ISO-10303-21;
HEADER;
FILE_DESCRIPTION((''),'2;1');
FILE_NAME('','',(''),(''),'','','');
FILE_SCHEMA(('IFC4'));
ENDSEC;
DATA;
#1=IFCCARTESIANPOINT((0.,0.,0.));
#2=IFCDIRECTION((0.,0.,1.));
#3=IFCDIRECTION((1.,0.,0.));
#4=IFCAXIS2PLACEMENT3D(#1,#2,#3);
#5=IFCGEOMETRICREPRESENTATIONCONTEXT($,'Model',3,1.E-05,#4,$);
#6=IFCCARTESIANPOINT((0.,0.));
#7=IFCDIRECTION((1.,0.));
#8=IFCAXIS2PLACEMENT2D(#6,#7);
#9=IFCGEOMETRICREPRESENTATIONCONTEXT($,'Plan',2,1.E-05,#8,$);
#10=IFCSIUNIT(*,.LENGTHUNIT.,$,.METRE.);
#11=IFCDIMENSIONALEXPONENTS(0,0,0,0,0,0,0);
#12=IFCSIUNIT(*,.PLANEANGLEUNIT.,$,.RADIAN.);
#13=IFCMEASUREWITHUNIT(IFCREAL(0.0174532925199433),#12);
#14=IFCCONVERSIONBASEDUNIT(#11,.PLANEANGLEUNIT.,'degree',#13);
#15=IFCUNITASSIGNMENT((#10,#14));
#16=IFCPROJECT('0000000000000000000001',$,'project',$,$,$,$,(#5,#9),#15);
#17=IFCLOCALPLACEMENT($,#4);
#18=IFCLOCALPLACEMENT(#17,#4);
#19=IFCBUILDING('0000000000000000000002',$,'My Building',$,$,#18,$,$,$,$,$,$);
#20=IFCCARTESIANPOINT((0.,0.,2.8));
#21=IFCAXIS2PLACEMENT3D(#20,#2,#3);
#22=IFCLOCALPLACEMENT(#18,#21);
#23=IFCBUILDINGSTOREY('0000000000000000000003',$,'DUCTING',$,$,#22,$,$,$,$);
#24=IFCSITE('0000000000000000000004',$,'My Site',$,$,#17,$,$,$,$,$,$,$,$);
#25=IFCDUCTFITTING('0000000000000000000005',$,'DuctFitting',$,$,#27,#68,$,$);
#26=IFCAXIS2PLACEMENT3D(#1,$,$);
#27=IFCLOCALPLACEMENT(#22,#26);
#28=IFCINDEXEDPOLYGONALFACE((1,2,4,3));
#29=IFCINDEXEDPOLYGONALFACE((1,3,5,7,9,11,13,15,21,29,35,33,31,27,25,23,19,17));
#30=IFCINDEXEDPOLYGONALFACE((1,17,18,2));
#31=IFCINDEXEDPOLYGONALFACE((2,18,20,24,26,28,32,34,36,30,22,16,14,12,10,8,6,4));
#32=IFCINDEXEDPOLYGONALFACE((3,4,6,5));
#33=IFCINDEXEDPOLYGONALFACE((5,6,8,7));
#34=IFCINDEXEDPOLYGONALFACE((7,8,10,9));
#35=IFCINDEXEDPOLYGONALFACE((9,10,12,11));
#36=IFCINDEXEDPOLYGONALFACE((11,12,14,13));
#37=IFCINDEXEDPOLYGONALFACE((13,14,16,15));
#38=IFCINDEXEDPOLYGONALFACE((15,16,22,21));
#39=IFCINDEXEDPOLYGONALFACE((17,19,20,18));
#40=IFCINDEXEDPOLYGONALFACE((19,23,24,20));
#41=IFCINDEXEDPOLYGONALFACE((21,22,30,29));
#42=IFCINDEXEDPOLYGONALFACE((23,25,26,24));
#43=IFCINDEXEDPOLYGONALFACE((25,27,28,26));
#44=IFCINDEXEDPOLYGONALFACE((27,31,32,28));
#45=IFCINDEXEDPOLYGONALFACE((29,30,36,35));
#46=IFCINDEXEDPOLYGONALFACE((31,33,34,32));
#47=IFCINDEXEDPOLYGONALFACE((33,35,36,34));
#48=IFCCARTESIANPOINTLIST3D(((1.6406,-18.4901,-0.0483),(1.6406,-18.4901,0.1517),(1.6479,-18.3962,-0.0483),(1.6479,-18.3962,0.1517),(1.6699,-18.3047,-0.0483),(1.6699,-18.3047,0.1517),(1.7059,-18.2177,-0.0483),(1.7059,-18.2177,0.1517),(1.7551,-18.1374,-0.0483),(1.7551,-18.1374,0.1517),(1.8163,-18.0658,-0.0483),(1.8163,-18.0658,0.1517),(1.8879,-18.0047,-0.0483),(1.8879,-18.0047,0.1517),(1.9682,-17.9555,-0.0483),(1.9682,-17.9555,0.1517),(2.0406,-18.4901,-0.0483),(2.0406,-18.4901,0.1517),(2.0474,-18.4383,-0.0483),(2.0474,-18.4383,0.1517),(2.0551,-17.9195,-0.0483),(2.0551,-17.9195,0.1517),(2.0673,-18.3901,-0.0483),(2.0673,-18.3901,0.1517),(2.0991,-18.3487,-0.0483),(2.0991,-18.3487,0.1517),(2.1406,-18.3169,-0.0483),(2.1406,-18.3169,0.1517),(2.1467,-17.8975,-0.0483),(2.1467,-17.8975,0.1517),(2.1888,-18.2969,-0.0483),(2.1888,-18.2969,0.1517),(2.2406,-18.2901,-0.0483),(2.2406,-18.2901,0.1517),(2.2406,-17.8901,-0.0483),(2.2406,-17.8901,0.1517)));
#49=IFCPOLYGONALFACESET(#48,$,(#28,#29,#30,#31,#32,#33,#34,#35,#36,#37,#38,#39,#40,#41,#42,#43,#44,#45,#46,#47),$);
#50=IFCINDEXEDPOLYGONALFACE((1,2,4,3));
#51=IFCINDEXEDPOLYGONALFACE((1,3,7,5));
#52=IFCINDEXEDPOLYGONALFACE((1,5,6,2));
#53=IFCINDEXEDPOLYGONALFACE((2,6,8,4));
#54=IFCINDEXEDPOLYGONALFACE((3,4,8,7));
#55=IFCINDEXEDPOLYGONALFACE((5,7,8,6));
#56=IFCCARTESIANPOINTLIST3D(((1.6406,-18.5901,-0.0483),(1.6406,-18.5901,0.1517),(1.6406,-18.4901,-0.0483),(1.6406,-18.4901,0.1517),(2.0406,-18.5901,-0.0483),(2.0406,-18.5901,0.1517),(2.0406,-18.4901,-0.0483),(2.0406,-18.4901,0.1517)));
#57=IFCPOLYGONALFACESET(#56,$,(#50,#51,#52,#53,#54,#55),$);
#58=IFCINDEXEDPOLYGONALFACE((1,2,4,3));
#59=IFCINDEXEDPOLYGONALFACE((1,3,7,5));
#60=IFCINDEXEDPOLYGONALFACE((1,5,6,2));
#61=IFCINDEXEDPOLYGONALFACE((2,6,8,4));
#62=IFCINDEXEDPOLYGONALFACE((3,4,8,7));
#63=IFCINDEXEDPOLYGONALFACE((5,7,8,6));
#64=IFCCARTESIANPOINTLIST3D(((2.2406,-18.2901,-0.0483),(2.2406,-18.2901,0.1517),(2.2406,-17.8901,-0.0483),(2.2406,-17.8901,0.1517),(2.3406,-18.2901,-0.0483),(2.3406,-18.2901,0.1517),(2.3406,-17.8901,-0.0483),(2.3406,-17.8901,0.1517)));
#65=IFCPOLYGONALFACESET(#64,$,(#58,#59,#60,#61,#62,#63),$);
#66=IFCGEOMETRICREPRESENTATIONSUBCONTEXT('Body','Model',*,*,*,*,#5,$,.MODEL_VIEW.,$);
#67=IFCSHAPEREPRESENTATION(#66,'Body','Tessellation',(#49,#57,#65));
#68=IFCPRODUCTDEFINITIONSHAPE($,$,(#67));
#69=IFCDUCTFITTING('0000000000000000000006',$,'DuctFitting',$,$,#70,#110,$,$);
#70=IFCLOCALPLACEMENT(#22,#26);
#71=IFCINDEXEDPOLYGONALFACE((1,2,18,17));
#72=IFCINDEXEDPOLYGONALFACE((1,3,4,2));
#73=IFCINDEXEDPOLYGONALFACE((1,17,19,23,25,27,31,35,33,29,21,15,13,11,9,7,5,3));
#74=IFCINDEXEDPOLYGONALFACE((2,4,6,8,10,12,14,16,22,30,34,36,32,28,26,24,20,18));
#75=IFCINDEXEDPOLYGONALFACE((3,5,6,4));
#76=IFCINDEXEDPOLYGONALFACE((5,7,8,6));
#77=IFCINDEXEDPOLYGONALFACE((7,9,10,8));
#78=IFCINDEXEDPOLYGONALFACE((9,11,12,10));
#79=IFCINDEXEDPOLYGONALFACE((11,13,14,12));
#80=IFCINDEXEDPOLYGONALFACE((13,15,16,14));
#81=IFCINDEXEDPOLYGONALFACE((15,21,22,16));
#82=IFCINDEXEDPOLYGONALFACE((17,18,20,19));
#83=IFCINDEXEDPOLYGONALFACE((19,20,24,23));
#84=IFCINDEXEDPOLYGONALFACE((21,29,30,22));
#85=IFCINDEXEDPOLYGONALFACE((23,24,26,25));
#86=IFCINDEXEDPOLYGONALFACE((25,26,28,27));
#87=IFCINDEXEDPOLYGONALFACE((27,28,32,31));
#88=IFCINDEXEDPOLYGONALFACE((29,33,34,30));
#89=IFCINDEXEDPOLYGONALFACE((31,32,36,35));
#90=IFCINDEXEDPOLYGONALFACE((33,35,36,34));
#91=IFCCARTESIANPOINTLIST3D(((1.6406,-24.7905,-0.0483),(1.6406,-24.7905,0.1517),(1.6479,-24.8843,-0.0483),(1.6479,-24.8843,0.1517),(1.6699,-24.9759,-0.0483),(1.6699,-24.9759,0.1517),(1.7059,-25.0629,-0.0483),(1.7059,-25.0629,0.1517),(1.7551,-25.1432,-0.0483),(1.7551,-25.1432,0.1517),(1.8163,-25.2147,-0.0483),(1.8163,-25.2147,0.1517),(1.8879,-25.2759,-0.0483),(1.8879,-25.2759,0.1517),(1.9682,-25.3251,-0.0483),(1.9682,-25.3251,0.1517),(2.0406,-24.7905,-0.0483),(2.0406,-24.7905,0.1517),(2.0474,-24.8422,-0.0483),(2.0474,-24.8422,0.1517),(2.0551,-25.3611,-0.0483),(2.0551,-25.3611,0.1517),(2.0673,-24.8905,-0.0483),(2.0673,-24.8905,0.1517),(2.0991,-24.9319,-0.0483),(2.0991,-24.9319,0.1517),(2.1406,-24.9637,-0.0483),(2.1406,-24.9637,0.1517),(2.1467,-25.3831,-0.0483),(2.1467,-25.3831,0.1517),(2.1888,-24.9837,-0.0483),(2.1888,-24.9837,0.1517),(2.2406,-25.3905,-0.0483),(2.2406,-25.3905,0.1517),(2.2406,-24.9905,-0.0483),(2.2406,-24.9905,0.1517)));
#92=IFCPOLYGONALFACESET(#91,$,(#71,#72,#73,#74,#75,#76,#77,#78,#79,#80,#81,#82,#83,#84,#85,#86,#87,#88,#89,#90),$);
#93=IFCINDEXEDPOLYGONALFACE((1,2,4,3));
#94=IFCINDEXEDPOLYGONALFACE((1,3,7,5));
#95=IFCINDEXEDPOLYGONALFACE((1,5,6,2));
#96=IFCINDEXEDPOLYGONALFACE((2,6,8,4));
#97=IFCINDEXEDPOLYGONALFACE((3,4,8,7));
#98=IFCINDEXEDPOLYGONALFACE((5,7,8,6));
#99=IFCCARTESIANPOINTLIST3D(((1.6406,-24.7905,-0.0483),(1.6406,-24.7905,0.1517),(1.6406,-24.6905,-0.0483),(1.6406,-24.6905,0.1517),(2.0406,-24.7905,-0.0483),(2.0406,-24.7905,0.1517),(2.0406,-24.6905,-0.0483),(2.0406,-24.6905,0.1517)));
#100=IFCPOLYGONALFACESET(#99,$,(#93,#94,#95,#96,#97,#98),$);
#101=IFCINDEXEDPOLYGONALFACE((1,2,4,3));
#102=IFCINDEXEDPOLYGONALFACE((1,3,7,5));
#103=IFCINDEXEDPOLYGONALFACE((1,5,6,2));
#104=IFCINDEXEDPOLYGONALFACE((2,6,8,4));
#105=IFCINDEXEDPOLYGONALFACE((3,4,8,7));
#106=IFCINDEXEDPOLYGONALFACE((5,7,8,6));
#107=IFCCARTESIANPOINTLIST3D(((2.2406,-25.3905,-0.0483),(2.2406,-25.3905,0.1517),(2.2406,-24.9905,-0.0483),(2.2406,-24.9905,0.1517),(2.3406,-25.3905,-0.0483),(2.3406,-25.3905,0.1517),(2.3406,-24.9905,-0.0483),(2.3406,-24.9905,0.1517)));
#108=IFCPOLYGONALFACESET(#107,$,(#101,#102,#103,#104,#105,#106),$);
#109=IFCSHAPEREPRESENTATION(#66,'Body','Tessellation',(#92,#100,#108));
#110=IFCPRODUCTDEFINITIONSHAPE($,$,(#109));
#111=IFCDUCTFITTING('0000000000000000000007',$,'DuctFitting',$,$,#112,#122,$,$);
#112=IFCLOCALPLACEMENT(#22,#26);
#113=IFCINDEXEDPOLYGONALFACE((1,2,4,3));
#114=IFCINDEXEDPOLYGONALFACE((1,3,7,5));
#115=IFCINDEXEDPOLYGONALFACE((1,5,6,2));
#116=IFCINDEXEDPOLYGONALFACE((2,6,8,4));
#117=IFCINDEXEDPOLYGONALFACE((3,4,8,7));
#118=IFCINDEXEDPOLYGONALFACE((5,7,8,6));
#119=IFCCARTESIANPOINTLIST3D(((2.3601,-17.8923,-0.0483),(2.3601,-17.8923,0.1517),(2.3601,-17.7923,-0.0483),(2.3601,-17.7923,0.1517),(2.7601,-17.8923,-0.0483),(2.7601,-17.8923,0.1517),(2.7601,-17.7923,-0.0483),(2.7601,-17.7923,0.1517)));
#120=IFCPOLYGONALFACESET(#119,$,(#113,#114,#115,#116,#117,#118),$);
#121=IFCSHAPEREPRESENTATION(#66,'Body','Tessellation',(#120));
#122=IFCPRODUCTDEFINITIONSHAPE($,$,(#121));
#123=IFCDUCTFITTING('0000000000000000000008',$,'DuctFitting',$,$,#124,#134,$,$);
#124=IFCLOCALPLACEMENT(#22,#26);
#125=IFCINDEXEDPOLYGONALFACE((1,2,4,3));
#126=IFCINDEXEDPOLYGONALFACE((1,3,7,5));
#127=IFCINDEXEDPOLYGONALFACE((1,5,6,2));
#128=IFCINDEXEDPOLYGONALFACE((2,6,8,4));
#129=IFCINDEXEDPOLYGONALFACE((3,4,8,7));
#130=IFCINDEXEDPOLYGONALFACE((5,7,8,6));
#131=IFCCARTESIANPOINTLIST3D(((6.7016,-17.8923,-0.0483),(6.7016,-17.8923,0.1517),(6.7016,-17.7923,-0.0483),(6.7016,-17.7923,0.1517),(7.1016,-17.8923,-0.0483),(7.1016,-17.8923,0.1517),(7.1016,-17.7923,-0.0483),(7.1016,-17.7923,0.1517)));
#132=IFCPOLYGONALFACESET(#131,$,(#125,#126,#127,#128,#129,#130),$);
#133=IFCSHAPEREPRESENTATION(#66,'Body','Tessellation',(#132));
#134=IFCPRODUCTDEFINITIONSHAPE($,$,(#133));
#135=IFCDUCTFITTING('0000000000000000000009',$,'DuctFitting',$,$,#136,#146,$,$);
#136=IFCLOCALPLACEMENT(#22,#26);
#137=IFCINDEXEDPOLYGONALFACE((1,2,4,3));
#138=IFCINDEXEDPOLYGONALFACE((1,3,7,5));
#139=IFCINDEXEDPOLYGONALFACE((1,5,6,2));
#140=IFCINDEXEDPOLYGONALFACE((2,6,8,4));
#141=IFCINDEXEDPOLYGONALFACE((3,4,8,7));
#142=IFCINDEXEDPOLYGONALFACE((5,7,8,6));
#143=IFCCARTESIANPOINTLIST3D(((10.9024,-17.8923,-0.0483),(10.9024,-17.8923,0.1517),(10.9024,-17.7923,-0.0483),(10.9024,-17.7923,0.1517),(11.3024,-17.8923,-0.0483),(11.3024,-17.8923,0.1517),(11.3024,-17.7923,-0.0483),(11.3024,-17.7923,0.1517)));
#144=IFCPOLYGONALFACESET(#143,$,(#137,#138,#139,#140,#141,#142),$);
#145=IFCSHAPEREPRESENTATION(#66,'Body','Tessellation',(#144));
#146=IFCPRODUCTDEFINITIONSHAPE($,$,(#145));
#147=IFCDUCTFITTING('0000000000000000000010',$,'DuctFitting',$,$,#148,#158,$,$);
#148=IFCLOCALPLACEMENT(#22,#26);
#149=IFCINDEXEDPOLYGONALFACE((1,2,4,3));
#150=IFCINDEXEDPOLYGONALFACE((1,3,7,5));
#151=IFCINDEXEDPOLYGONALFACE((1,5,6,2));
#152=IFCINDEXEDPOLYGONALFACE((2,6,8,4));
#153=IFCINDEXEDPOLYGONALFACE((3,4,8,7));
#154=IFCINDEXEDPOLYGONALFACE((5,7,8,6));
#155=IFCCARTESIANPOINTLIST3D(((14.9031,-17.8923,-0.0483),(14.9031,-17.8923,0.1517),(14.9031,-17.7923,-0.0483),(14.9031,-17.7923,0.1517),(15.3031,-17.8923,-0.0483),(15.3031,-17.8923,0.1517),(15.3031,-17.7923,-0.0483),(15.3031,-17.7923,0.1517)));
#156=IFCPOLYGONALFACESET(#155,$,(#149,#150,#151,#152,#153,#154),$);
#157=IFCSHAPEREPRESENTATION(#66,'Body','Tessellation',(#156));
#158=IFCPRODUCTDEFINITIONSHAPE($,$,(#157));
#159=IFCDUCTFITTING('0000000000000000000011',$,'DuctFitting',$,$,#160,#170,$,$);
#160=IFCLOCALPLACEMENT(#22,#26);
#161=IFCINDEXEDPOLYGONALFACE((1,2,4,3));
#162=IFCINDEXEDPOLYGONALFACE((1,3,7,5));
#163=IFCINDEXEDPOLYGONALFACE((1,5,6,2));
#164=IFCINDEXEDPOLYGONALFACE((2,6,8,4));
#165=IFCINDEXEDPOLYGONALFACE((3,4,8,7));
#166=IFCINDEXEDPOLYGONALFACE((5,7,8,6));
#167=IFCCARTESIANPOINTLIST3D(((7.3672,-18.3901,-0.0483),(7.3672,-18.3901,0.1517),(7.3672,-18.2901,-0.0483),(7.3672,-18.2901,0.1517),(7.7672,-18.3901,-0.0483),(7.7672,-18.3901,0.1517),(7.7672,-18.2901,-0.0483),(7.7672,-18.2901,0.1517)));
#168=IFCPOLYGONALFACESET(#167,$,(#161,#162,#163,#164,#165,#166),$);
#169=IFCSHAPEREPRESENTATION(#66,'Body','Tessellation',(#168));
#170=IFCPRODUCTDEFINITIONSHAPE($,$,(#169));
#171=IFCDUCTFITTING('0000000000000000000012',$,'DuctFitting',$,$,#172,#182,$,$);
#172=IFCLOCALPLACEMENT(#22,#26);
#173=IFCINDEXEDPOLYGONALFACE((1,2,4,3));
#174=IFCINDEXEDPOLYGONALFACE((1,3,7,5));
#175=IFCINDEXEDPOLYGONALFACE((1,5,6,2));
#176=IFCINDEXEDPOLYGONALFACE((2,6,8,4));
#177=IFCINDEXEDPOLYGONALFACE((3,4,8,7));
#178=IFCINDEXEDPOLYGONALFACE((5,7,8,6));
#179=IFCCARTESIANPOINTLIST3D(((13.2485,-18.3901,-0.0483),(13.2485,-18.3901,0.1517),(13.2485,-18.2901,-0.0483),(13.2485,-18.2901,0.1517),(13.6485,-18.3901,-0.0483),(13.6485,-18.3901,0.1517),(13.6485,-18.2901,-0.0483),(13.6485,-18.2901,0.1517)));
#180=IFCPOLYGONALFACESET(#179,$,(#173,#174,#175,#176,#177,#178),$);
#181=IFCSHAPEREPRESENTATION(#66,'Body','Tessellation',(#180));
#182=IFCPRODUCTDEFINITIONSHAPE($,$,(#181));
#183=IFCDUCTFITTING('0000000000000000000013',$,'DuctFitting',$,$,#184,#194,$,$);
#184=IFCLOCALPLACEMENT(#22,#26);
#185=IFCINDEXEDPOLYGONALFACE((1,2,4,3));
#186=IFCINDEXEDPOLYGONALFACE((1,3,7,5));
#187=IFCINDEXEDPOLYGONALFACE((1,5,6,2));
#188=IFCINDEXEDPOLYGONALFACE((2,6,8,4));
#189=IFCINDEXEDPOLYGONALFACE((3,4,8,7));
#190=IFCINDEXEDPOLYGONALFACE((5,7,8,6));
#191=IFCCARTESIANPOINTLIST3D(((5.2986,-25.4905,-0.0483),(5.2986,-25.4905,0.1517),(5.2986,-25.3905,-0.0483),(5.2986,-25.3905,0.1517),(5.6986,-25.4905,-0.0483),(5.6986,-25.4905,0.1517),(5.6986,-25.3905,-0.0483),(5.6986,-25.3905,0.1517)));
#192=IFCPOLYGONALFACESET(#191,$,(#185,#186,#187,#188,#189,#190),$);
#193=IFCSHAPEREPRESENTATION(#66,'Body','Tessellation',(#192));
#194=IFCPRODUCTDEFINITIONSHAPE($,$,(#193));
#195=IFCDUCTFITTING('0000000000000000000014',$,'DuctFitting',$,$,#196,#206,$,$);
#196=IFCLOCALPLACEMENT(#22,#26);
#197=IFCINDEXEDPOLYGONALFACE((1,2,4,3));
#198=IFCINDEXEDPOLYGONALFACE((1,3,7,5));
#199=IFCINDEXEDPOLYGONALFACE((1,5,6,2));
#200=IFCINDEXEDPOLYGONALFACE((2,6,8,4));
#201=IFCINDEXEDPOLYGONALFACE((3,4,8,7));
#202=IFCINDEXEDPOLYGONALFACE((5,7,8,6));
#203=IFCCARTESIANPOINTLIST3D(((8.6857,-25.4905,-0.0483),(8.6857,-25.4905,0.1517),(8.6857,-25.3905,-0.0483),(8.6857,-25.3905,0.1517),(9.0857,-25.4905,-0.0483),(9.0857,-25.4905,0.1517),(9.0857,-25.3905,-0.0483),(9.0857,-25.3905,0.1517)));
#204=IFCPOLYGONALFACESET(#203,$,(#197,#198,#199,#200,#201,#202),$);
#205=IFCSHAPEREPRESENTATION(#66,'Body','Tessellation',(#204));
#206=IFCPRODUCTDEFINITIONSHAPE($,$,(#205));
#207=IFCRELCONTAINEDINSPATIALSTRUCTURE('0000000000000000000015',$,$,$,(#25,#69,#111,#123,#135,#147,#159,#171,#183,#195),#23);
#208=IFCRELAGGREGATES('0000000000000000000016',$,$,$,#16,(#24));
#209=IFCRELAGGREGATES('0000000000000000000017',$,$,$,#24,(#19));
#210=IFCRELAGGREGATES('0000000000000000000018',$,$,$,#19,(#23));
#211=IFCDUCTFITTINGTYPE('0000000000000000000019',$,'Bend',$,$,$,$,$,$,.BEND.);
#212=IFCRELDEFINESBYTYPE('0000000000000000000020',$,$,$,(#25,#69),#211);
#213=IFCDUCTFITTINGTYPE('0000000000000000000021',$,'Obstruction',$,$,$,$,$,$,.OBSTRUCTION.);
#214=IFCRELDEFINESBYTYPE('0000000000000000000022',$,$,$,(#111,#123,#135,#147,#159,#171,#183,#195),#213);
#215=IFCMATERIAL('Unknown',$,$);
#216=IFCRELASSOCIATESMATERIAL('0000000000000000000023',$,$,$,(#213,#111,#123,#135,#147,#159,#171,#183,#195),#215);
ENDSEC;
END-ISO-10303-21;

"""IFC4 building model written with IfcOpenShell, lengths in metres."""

from ifc_helpers import new_model, entity, si_unit, converted_unit, frame, origin_with_axes, origin_2d_with_axis, place, context, subcontext, project, spatial, line, arc, indexed_curve, rectangle, outline, extrude, source, transform, mapped, material, material_profile, profile_set, profile_usage, type_object, type_shapes, element, save


model = new_model("IFC4")

# Units and contexts
model_context = context("Model", 3, precision=1e-05, world=origin_with_axes())
plan_context = context("Plan", 2, precision=1e-05, world=origin_2d_with_axis())
body_context = subcontext(model_context, "Body", "Model", "MODEL_VIEW")
ifc_project = project(units=[si_unit("LENGTHUNIT", "METRE"), converted_unit("PLANEANGLEUNIT", "degree", entity("IfcReal", 0.0174532925199433), si_unit("PLANEANGLEUNIT", "RADIAN"), dimensions=[0, 0, 0, 0, 0, 0, 0])], contexts=[model_context, plan_context])

# Site, building, storey
site_placement = place(None, origin_with_axes())
site = spatial("IfcSite", under=ifc_project, at=site_placement, Name="My Site")
building_placement = place(site_placement, origin_with_axes())
building = spatial("IfcBuilding", under=site, at=building_placement, Name="My Building")
storey_placement = place(building_placement, frame((0.0, 0.0, 2.8), z_axis=(0.0, 0.0, 1.0), x_axis=(1.0, 0.0, 0.0)))
storey = spatial("IfcBuildingStorey", under=building, at=storey_placement, Name="DUCTING")

# Shared definitions
ifc_material = material(Name="Unknown")

# Duct fittings
duct_fitting_type_1 = type_object("IfcDuctFittingType", Name="Bend", PredefinedType="BEND")
shared_shape = source(origin_with_axes(), body_context, "Body", "SweptSolid", [
    extrude(outline(indexed_curve([(0.2, 0.0), (0.2586, -0.1414), (0.4, -0.2), (0.4, -0.6), (-0.0243, -0.4243), (-0.2, 0.0)], segments=[arc(1, 2, 3), line(3, 4), arc(4, 5, 6), line(6, 1)])), frame((0.0, -0.1, -0.1), z_axis=(0.0, -1.0, 0.0), x_axis=(1.0, 0.0, 0.0)), (0.0, 0.0, -1.0), 0.2),
    extrude(rectangle(XDim=0.4, YDim=0.2), origin_with_axes(), (0.0, 0.0, -1.0), 0.1),
    extrude(rectangle(XDim=0.4, YDim=0.2), frame((0.4, 0.0, -0.5), z_axis=(1.0, 0.0, 0.0), x_axis=(0.0, 0.0, 1.0)), (0.0, 0.0, 1.0), 0.1),
])
type_shapes(duct_fitting_type_1, [shared_shape])
for number, where, z_axis, x_axis, name in (
    (1, (1.8406, -18.5901, 0.0517), (0.0, -1.0, 0.0), (1.0, 0.0, 0.0), "DuctFitting"),
    (2, (1.8406, -24.6905, 0.0517), (0.0, 1.0, 0.0), (1.0, 0.0, 0.0), "DuctFitting"),
):
    element("IfcDuctFitting", number, at=place(storey_placement, frame(where, z_axis=z_axis, x_axis=x_axis)), inside=storey, type_object=duct_fitting_type_1, Name=name, context=body_context, shape_type="MappedRepresentation", body=[
        mapped(shared_shape, transform((0.0, 0.0, 0.0), x_axis=(1.0, 0.0, 0.0), y_axis=(0.0, 1.0, 0.0), z_axis=(0.0, 0.0, 1.0), scale=1.0)),
    ])
ifc_material_profile_1 = material_profile(ifc_material, rectangle(XDim=0.4, YDim=0.2))
ifc_profile_set_1 = profile_set([ifc_material_profile_1])
ifc_profile_usage_1 = profile_usage(ifc_profile_set_1, cardinal=5)
duct_fitting_type_2 = type_object("IfcDuctFittingType", Name="Obstruction", PredefinedType="OBSTRUCTION", material=ifc_profile_set_1)
duct_fitting_1_placement = place(storey_placement, frame((2.5601, -17.7923, 0.0517), z_axis=(0.0, -1.0, 0.0), x_axis=(1.0, 0.0, 0.0)))
element("IfcDuctFitting", 3, at=duct_fitting_1_placement, inside=storey, type_object=duct_fitting_type_2, material=ifc_profile_usage_1, Name="DuctFitting", context=body_context, shape_type="SweptSolid", body=[
    extrude(rectangle(XDim=0.4, YDim=0.2), origin_with_axes(), (0.0, 0.0, 1.0), 0.1),
])
ifc_profile_usage_2 = profile_usage(ifc_profile_set_1, cardinal=5)
duct_fitting_2_placement = place(storey_placement, frame((6.9016, -17.7923, 0.0517), z_axis=(0.0, -1.0, 0.0), x_axis=(1.0, 0.0, 0.0)))
element("IfcDuctFitting", 4, at=duct_fitting_2_placement, inside=storey, type_object=duct_fitting_type_2, material=ifc_profile_usage_2, Name="DuctFitting", context=body_context, shape_type="SweptSolid", body=[
    extrude(rectangle(XDim=0.4, YDim=0.2), origin_with_axes(), (0.0, 0.0, 1.0), 0.1),
])
ifc_profile_usage_3 = profile_usage(ifc_profile_set_1, cardinal=5)
duct_fitting_3_placement = place(storey_placement, frame((11.1024, -17.7923, 0.0517), z_axis=(0.0, -1.0, 0.0), x_axis=(1.0, 0.0, 0.0)))
element("IfcDuctFitting", 5, at=duct_fitting_3_placement, inside=storey, type_object=duct_fitting_type_2, material=ifc_profile_usage_3, Name="DuctFitting", context=body_context, shape_type="SweptSolid", body=[
    extrude(rectangle(XDim=0.4, YDim=0.2), origin_with_axes(), (0.0, 0.0, 1.0), 0.1),
])
ifc_profile_usage_4 = profile_usage(ifc_profile_set_1, cardinal=5)
duct_fitting_4_placement = place(storey_placement, frame((15.1031, -17.7923, 0.0517), z_axis=(0.0, -1.0, 0.0), x_axis=(1.0, 0.0, 0.0)))
element("IfcDuctFitting", 6, at=duct_fitting_4_placement, inside=storey, type_object=duct_fitting_type_2, material=ifc_profile_usage_4, Name="DuctFitting", context=body_context, shape_type="SweptSolid", body=[
    extrude(rectangle(XDim=0.4, YDim=0.2), origin_with_axes(), (0.0, 0.0, 1.0), 0.1),
])
ifc_profile_usage_5 = profile_usage(ifc_profile_set_1, cardinal=5)
duct_fitting_5_placement = place(storey_placement, frame((7.5672, -18.3901, 0.0517), z_axis=(0.0, 1.0, 0.0), x_axis=(-1.0, 0.0, 0.0)))
element("IfcDuctFitting", 7, at=duct_fitting_5_placement, inside=storey, type_object=duct_fitting_type_2, material=ifc_profile_usage_5, Name="DuctFitting", context=body_context, shape_type="SweptSolid", body=[
    extrude(rectangle(XDim=0.4, YDim=0.2), origin_with_axes(), (0.0, 0.0, 1.0), 0.1),
])
ifc_profile_usage_6 = profile_usage(ifc_profile_set_1, cardinal=5)
duct_fitting_6_placement = place(storey_placement, frame((13.4485, -18.3901, 0.0517), z_axis=(0.0, 1.0, 0.0), x_axis=(-1.0, 0.0, 0.0)))
element("IfcDuctFitting", 8, at=duct_fitting_6_placement, inside=storey, type_object=duct_fitting_type_2, material=ifc_profile_usage_6, Name="DuctFitting", context=body_context, shape_type="SweptSolid", body=[
    extrude(rectangle(XDim=0.4, YDim=0.2), origin_with_axes(), (0.0, 0.0, 1.0), 0.1),
])
ifc_profile_usage_7 = profile_usage(ifc_profile_set_1, cardinal=5)
duct_fitting_7_placement = place(storey_placement, frame((5.4986, -25.4905, 0.0517), z_axis=(0.0, 1.0, 0.0), x_axis=(-1.0, 0.0, 0.0)))
element("IfcDuctFitting", 9, at=duct_fitting_7_placement, inside=storey, type_object=duct_fitting_type_2, material=ifc_profile_usage_7, Name="DuctFitting", context=body_context, shape_type="SweptSolid", body=[
    extrude(rectangle(XDim=0.4, YDim=0.2), origin_with_axes(), (0.0, 0.0, 1.0), 0.1),
])
ifc_profile_usage_8 = profile_usage(ifc_profile_set_1, cardinal=5)
duct_fitting_8_placement = place(storey_placement, frame((8.8857, -25.4905, 0.0517), z_axis=(0.0, 1.0, 0.0), x_axis=(-1.0, 0.0, 0.0)))
element("IfcDuctFitting", 10, at=duct_fitting_8_placement, inside=storey, type_object=duct_fitting_type_2, material=ifc_profile_usage_8, Name="DuctFitting", context=body_context, shape_type="SweptSolid", body=[
    extrude(rectangle(XDim=0.4, YDim=0.2), origin_with_axes(), (0.0, 0.0, 1.0), 0.1),
])

save(model, "model.ifc")
